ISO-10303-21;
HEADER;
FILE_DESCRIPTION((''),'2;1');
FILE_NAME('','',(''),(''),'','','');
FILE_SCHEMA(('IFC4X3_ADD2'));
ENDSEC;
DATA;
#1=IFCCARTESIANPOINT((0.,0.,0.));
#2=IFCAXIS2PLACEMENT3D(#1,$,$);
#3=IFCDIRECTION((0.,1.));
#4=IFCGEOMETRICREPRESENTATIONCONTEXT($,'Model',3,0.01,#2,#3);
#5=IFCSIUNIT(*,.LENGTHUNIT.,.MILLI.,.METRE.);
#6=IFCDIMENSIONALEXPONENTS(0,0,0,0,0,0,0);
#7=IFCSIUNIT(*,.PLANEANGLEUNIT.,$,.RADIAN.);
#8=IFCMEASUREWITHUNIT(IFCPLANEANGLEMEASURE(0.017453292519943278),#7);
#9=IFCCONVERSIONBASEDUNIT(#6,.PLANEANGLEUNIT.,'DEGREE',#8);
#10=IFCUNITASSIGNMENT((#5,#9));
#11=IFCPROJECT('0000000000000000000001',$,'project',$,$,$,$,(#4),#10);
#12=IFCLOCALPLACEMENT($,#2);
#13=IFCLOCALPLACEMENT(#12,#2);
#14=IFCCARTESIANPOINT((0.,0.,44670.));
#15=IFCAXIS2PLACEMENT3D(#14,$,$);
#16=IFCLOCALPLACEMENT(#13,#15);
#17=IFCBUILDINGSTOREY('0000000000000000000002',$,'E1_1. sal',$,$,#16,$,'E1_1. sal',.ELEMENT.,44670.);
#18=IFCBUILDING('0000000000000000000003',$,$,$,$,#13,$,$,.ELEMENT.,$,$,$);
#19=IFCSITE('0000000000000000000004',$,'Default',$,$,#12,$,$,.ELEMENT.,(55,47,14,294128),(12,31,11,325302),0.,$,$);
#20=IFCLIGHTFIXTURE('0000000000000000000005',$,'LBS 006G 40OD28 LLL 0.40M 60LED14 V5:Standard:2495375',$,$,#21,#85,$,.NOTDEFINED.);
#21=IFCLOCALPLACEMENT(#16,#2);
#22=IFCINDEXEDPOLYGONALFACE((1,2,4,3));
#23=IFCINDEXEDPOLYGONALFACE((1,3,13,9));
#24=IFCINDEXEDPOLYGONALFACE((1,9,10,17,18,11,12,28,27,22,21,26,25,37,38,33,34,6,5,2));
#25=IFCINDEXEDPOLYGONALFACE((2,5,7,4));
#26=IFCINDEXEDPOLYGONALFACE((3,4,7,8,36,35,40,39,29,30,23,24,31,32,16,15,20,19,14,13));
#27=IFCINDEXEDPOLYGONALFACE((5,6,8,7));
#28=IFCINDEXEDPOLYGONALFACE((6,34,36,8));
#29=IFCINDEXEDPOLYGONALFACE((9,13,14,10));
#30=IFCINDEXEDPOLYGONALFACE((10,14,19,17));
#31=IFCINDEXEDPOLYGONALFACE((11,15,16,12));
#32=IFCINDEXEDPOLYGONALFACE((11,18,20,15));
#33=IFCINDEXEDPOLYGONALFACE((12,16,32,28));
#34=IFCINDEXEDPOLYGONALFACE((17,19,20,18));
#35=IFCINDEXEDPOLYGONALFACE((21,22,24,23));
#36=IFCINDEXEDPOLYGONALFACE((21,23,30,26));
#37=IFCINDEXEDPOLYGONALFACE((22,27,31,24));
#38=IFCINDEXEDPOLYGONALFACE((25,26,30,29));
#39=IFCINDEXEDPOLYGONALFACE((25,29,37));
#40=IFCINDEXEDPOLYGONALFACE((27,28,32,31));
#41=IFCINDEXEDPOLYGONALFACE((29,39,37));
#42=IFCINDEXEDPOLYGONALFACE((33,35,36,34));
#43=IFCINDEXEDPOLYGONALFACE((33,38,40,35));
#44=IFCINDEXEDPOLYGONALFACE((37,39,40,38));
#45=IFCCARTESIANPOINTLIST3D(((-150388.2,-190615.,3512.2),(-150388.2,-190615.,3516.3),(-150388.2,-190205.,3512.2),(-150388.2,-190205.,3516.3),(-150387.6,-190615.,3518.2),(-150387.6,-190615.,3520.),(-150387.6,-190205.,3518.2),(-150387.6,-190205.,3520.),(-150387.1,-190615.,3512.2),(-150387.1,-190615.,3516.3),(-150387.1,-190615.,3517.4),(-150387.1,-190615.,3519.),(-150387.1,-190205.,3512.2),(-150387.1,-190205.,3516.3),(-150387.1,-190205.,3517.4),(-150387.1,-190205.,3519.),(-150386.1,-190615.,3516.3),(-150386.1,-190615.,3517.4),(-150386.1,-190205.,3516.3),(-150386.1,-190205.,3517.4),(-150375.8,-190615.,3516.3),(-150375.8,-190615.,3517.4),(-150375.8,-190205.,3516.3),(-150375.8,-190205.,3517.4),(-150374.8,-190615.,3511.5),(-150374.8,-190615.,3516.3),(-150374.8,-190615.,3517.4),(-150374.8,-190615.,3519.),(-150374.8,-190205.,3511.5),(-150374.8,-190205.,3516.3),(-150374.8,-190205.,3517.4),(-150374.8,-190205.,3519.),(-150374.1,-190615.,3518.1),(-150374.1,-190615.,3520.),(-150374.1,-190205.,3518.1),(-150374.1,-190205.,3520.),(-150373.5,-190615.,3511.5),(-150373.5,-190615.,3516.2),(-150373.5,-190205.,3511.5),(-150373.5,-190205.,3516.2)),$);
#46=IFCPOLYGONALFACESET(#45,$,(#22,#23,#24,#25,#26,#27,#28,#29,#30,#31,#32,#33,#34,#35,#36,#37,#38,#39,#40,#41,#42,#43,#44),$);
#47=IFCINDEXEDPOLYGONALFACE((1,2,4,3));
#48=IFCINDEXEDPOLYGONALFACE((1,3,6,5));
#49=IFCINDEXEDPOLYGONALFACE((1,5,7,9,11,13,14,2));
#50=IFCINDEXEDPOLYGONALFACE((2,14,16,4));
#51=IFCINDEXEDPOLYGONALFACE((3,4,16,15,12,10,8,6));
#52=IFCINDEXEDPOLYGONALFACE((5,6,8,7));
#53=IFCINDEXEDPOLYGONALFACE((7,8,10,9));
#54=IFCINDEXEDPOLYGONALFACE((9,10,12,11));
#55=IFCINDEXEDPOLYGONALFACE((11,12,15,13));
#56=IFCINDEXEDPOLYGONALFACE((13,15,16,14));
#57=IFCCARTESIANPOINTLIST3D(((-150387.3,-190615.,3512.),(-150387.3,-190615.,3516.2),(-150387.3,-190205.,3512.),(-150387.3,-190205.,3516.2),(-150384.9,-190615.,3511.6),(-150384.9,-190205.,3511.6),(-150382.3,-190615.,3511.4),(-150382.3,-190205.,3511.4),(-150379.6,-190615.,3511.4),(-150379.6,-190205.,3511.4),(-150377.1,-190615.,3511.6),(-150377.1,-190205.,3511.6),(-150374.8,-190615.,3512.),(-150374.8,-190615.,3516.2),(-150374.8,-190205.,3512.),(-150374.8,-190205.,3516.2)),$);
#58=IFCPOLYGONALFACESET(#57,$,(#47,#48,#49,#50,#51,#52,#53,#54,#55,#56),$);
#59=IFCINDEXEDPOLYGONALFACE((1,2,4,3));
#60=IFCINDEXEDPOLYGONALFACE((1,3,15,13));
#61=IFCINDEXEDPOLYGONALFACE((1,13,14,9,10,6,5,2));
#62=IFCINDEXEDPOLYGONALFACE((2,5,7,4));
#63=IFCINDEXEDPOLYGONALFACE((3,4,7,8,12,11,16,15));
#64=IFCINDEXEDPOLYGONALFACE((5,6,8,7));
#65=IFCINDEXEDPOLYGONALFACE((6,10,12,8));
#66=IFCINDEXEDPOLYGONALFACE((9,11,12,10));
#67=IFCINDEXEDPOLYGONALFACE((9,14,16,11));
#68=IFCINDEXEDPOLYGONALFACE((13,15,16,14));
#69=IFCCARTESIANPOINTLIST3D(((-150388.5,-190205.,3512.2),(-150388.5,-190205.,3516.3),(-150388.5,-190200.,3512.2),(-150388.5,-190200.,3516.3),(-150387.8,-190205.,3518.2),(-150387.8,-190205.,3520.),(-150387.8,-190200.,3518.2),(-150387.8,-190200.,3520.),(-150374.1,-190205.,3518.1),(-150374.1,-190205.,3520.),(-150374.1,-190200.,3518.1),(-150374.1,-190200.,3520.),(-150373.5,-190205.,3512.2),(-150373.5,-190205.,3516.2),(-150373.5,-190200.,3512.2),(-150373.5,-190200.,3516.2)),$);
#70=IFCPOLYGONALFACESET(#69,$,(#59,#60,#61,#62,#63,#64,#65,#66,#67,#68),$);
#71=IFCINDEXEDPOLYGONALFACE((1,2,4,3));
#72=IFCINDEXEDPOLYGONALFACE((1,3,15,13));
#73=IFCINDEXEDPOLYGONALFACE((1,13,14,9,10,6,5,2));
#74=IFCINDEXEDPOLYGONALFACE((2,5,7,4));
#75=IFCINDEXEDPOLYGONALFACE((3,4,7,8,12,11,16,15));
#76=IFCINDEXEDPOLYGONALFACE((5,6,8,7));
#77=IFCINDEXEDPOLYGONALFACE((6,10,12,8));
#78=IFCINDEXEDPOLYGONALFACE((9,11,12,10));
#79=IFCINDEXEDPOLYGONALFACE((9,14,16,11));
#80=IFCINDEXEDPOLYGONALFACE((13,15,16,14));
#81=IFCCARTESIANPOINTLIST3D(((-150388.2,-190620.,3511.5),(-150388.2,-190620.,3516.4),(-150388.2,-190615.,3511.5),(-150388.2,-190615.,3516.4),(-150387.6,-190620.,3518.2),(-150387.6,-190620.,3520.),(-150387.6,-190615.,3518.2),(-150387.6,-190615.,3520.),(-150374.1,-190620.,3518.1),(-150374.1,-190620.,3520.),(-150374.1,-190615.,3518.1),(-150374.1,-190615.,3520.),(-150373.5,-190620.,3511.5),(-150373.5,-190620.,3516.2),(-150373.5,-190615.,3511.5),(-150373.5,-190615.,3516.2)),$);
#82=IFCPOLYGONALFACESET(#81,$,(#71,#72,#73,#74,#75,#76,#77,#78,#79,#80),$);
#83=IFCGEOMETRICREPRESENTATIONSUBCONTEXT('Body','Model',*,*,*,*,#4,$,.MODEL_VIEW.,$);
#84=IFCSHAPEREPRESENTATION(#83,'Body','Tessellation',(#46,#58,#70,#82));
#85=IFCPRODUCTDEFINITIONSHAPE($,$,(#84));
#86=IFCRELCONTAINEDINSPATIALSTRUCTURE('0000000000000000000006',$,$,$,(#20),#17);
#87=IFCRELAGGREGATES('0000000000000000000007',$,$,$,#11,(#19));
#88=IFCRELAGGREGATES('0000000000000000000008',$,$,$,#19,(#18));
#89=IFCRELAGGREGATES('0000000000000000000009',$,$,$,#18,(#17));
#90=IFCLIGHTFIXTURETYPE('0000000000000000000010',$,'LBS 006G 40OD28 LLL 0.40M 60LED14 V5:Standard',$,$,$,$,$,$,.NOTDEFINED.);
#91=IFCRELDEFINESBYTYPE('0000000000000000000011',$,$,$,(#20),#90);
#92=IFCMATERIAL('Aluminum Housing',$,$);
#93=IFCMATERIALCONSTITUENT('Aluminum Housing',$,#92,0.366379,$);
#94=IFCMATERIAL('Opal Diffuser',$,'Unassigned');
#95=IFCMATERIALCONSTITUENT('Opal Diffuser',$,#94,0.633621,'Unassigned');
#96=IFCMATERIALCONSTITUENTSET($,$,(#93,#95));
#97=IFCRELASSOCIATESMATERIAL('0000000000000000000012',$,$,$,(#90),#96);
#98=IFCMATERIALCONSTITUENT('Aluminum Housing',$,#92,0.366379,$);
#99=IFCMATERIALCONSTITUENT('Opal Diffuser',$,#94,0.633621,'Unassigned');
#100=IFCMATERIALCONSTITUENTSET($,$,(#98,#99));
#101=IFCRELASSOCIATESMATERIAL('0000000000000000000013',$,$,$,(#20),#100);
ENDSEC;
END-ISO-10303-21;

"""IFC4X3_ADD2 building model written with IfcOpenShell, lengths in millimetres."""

from ifc_helpers import new_model, entity, si_unit, converted_unit, direction, frame, origin, place, context, subcontext, project, spatial, polyline, outline, extrude, source, transform, mapped, material, constituent, constituent_set, type_object, type_shapes, element, save


model = new_model("IFC4X3_ADD2")

# Units and contexts
model_context = context("Model", 3, precision=0.01, world=origin(), true_north=direction((0.0, 1.0)))
body_context = subcontext(model_context, "Body", "Model", "MODEL_VIEW")
ifc_project = project(units=[si_unit("LENGTHUNIT", "METRE", prefix="MILLI"), converted_unit("PLANEANGLEUNIT", "DEGREE", entity("IfcPlaneAngleMeasure", 0.017453292519943278), si_unit("PLANEANGLEUNIT", "RADIAN"), dimensions=[0, 0, 0, 0, 0, 0, 0])], contexts=[model_context])

# Site, building, storey
site_placement = place(None, origin())
site = spatial("IfcSite", under=ifc_project, at=site_placement, Name="Default", CompositionType="ELEMENT", RefLatitude=(55, 47, 14, 294128), RefLongitude=(12, 31, 11, 325302), RefElevation=0.0)
building_placement = place(site_placement, origin())
building = spatial("IfcBuilding", under=site, at=building_placement, CompositionType="ELEMENT")
storey_placement = place(building_placement, frame((0.0, 0.0, 44670.0)))
storey = spatial("IfcBuildingStorey", under=building, at=storey_placement, Name="E1_1. sal", LongName="E1_1. sal", CompositionType="ELEMENT", Elevation=44670.0)

# Light fixture
ifc_material_1 = material(Name="Aluminum Housing")
ifc_constituent_1 = constituent(ifc_material_1, Name="Aluminum Housing", fraction=0.366379)
ifc_material_2 = material(Name="Opal Diffuser", Category="Unassigned")
ifc_constituent_2 = constituent(ifc_material_2, Name="Opal Diffuser", Category="Unassigned", fraction=0.633621)
ifc_constituent_set_1 = constituent_set(constituents=[ifc_constituent_1, ifc_constituent_2])
ifc_constituent_3 = constituent(ifc_material_1, Name="Aluminum Housing", fraction=0.366379)
ifc_constituent_4 = constituent(ifc_material_2, Name="Opal Diffuser", Category="Unassigned", fraction=0.633621)
ifc_constituent_set_2 = constituent_set(constituents=[ifc_constituent_3, ifc_constituent_4])
light_fixture_type = type_object("IfcLightFixtureType", Name="LBS 006G 40OD28 LLL 0.40M 60LED14 V5:Standard", PredefinedType="NOTDEFINED", material=ifc_constituent_set_2)
shared_shape_1 = source(origin(), body_context, "Body", "SweptSolid", [
    extrude(outline(polyline([(-5.0, -6.1), (-5.0, -7.4), (-0.3, -7.4), (1.7, -6.8), (3.5, -6.8), (3.5, 6.7), (1.8, 6.7), (-0.1, 7.3), (-4.2, 7.3), (-4.2, 6.2), (-0.1, 6.2), (-0.1, 5.2), (0.9, 5.2), (0.9, 6.2), (2.5, 6.2), (2.5, -6.1), (0.9, -6.1), (0.9, -5.1), (-0.1, -5.1), (-0.1, -6.1), (-5.0, -6.1)])), frame((-205.0, 0.1, 3.5), z_axis=(-1.0, 0.0, 0.0), x_axis=(0.0, 0.0, -1.0)), (0.0, 0.0, -1.0), 410.0),
    extrude(outline(polyline([(-0.8, -6.2), (3.4, -6.2), (3.4, 6.2), (-0.8, 6.2), (-1.2, 3.9), (-1.4, 1.4), (-1.4, -1.3), (-1.2, -3.9), (-0.8, -6.2)])), frame((-205.0, 0.0, 7.2), z_axis=(1.0, 0.0, 0.0), x_axis=(0.0, 0.0, -1.0)), (0.0, 0.0, 1.0), 410.0),
    extrude(outline(polyline([(-4.4, -7.5), (-0.3, -7.5), (1.5, -6.8), (3.3, -6.8), (3.3, 6.9), (1.5, 6.9), (-0.5, 7.4), (-4.4, 7.4), (-4.4, -7.5)])), frame((205.0, 0.0, 3.3), z_axis=(1.0, 0.0, 0.0), x_axis=(0.0, 0.0, -1.0)), (0.0, 0.0, 1.0), 5.0),
    extrude(outline(polyline([(-5.0, -7.4), (-0.1, -7.4), (1.7, -6.7), (3.5, -6.7), (3.5, 6.8), (1.6, 6.8), (-0.3, 7.3), (-5.0, 7.3), (-5.0, -7.4)])), frame((-210.0, 0.2, 3.5), z_axis=(1.0, 0.0, 0.0), x_axis=(0.0, 0.0, -1.0)), (0.0, 0.0, 1.0), 5.0),
])
type_shapes(light_fixture_type, [shared_shape_1])
light_fixture_placement = place(storey_placement, frame((-150381.0, -190410.0, 3520.0), z_axis=(0.0, 0.0, -1.0), x_axis=(0.0, 1.0, 0.0)))
element("IfcLightFixture", 1, at=light_fixture_placement, inside=storey, type_object=light_fixture_type, material=ifc_constituent_set_1, Name="LBS 006G 40OD28 LLL 0.40M 60LED14 V5:Standard:2495375", PredefinedType="NOTDEFINED", context=body_context, shape_type="MappedRepresentation", body=[
    mapped(shared_shape_1, transform((0.0, 0.0, 0.0), scale=1.0)),
])

save(model, "model.ifc")
